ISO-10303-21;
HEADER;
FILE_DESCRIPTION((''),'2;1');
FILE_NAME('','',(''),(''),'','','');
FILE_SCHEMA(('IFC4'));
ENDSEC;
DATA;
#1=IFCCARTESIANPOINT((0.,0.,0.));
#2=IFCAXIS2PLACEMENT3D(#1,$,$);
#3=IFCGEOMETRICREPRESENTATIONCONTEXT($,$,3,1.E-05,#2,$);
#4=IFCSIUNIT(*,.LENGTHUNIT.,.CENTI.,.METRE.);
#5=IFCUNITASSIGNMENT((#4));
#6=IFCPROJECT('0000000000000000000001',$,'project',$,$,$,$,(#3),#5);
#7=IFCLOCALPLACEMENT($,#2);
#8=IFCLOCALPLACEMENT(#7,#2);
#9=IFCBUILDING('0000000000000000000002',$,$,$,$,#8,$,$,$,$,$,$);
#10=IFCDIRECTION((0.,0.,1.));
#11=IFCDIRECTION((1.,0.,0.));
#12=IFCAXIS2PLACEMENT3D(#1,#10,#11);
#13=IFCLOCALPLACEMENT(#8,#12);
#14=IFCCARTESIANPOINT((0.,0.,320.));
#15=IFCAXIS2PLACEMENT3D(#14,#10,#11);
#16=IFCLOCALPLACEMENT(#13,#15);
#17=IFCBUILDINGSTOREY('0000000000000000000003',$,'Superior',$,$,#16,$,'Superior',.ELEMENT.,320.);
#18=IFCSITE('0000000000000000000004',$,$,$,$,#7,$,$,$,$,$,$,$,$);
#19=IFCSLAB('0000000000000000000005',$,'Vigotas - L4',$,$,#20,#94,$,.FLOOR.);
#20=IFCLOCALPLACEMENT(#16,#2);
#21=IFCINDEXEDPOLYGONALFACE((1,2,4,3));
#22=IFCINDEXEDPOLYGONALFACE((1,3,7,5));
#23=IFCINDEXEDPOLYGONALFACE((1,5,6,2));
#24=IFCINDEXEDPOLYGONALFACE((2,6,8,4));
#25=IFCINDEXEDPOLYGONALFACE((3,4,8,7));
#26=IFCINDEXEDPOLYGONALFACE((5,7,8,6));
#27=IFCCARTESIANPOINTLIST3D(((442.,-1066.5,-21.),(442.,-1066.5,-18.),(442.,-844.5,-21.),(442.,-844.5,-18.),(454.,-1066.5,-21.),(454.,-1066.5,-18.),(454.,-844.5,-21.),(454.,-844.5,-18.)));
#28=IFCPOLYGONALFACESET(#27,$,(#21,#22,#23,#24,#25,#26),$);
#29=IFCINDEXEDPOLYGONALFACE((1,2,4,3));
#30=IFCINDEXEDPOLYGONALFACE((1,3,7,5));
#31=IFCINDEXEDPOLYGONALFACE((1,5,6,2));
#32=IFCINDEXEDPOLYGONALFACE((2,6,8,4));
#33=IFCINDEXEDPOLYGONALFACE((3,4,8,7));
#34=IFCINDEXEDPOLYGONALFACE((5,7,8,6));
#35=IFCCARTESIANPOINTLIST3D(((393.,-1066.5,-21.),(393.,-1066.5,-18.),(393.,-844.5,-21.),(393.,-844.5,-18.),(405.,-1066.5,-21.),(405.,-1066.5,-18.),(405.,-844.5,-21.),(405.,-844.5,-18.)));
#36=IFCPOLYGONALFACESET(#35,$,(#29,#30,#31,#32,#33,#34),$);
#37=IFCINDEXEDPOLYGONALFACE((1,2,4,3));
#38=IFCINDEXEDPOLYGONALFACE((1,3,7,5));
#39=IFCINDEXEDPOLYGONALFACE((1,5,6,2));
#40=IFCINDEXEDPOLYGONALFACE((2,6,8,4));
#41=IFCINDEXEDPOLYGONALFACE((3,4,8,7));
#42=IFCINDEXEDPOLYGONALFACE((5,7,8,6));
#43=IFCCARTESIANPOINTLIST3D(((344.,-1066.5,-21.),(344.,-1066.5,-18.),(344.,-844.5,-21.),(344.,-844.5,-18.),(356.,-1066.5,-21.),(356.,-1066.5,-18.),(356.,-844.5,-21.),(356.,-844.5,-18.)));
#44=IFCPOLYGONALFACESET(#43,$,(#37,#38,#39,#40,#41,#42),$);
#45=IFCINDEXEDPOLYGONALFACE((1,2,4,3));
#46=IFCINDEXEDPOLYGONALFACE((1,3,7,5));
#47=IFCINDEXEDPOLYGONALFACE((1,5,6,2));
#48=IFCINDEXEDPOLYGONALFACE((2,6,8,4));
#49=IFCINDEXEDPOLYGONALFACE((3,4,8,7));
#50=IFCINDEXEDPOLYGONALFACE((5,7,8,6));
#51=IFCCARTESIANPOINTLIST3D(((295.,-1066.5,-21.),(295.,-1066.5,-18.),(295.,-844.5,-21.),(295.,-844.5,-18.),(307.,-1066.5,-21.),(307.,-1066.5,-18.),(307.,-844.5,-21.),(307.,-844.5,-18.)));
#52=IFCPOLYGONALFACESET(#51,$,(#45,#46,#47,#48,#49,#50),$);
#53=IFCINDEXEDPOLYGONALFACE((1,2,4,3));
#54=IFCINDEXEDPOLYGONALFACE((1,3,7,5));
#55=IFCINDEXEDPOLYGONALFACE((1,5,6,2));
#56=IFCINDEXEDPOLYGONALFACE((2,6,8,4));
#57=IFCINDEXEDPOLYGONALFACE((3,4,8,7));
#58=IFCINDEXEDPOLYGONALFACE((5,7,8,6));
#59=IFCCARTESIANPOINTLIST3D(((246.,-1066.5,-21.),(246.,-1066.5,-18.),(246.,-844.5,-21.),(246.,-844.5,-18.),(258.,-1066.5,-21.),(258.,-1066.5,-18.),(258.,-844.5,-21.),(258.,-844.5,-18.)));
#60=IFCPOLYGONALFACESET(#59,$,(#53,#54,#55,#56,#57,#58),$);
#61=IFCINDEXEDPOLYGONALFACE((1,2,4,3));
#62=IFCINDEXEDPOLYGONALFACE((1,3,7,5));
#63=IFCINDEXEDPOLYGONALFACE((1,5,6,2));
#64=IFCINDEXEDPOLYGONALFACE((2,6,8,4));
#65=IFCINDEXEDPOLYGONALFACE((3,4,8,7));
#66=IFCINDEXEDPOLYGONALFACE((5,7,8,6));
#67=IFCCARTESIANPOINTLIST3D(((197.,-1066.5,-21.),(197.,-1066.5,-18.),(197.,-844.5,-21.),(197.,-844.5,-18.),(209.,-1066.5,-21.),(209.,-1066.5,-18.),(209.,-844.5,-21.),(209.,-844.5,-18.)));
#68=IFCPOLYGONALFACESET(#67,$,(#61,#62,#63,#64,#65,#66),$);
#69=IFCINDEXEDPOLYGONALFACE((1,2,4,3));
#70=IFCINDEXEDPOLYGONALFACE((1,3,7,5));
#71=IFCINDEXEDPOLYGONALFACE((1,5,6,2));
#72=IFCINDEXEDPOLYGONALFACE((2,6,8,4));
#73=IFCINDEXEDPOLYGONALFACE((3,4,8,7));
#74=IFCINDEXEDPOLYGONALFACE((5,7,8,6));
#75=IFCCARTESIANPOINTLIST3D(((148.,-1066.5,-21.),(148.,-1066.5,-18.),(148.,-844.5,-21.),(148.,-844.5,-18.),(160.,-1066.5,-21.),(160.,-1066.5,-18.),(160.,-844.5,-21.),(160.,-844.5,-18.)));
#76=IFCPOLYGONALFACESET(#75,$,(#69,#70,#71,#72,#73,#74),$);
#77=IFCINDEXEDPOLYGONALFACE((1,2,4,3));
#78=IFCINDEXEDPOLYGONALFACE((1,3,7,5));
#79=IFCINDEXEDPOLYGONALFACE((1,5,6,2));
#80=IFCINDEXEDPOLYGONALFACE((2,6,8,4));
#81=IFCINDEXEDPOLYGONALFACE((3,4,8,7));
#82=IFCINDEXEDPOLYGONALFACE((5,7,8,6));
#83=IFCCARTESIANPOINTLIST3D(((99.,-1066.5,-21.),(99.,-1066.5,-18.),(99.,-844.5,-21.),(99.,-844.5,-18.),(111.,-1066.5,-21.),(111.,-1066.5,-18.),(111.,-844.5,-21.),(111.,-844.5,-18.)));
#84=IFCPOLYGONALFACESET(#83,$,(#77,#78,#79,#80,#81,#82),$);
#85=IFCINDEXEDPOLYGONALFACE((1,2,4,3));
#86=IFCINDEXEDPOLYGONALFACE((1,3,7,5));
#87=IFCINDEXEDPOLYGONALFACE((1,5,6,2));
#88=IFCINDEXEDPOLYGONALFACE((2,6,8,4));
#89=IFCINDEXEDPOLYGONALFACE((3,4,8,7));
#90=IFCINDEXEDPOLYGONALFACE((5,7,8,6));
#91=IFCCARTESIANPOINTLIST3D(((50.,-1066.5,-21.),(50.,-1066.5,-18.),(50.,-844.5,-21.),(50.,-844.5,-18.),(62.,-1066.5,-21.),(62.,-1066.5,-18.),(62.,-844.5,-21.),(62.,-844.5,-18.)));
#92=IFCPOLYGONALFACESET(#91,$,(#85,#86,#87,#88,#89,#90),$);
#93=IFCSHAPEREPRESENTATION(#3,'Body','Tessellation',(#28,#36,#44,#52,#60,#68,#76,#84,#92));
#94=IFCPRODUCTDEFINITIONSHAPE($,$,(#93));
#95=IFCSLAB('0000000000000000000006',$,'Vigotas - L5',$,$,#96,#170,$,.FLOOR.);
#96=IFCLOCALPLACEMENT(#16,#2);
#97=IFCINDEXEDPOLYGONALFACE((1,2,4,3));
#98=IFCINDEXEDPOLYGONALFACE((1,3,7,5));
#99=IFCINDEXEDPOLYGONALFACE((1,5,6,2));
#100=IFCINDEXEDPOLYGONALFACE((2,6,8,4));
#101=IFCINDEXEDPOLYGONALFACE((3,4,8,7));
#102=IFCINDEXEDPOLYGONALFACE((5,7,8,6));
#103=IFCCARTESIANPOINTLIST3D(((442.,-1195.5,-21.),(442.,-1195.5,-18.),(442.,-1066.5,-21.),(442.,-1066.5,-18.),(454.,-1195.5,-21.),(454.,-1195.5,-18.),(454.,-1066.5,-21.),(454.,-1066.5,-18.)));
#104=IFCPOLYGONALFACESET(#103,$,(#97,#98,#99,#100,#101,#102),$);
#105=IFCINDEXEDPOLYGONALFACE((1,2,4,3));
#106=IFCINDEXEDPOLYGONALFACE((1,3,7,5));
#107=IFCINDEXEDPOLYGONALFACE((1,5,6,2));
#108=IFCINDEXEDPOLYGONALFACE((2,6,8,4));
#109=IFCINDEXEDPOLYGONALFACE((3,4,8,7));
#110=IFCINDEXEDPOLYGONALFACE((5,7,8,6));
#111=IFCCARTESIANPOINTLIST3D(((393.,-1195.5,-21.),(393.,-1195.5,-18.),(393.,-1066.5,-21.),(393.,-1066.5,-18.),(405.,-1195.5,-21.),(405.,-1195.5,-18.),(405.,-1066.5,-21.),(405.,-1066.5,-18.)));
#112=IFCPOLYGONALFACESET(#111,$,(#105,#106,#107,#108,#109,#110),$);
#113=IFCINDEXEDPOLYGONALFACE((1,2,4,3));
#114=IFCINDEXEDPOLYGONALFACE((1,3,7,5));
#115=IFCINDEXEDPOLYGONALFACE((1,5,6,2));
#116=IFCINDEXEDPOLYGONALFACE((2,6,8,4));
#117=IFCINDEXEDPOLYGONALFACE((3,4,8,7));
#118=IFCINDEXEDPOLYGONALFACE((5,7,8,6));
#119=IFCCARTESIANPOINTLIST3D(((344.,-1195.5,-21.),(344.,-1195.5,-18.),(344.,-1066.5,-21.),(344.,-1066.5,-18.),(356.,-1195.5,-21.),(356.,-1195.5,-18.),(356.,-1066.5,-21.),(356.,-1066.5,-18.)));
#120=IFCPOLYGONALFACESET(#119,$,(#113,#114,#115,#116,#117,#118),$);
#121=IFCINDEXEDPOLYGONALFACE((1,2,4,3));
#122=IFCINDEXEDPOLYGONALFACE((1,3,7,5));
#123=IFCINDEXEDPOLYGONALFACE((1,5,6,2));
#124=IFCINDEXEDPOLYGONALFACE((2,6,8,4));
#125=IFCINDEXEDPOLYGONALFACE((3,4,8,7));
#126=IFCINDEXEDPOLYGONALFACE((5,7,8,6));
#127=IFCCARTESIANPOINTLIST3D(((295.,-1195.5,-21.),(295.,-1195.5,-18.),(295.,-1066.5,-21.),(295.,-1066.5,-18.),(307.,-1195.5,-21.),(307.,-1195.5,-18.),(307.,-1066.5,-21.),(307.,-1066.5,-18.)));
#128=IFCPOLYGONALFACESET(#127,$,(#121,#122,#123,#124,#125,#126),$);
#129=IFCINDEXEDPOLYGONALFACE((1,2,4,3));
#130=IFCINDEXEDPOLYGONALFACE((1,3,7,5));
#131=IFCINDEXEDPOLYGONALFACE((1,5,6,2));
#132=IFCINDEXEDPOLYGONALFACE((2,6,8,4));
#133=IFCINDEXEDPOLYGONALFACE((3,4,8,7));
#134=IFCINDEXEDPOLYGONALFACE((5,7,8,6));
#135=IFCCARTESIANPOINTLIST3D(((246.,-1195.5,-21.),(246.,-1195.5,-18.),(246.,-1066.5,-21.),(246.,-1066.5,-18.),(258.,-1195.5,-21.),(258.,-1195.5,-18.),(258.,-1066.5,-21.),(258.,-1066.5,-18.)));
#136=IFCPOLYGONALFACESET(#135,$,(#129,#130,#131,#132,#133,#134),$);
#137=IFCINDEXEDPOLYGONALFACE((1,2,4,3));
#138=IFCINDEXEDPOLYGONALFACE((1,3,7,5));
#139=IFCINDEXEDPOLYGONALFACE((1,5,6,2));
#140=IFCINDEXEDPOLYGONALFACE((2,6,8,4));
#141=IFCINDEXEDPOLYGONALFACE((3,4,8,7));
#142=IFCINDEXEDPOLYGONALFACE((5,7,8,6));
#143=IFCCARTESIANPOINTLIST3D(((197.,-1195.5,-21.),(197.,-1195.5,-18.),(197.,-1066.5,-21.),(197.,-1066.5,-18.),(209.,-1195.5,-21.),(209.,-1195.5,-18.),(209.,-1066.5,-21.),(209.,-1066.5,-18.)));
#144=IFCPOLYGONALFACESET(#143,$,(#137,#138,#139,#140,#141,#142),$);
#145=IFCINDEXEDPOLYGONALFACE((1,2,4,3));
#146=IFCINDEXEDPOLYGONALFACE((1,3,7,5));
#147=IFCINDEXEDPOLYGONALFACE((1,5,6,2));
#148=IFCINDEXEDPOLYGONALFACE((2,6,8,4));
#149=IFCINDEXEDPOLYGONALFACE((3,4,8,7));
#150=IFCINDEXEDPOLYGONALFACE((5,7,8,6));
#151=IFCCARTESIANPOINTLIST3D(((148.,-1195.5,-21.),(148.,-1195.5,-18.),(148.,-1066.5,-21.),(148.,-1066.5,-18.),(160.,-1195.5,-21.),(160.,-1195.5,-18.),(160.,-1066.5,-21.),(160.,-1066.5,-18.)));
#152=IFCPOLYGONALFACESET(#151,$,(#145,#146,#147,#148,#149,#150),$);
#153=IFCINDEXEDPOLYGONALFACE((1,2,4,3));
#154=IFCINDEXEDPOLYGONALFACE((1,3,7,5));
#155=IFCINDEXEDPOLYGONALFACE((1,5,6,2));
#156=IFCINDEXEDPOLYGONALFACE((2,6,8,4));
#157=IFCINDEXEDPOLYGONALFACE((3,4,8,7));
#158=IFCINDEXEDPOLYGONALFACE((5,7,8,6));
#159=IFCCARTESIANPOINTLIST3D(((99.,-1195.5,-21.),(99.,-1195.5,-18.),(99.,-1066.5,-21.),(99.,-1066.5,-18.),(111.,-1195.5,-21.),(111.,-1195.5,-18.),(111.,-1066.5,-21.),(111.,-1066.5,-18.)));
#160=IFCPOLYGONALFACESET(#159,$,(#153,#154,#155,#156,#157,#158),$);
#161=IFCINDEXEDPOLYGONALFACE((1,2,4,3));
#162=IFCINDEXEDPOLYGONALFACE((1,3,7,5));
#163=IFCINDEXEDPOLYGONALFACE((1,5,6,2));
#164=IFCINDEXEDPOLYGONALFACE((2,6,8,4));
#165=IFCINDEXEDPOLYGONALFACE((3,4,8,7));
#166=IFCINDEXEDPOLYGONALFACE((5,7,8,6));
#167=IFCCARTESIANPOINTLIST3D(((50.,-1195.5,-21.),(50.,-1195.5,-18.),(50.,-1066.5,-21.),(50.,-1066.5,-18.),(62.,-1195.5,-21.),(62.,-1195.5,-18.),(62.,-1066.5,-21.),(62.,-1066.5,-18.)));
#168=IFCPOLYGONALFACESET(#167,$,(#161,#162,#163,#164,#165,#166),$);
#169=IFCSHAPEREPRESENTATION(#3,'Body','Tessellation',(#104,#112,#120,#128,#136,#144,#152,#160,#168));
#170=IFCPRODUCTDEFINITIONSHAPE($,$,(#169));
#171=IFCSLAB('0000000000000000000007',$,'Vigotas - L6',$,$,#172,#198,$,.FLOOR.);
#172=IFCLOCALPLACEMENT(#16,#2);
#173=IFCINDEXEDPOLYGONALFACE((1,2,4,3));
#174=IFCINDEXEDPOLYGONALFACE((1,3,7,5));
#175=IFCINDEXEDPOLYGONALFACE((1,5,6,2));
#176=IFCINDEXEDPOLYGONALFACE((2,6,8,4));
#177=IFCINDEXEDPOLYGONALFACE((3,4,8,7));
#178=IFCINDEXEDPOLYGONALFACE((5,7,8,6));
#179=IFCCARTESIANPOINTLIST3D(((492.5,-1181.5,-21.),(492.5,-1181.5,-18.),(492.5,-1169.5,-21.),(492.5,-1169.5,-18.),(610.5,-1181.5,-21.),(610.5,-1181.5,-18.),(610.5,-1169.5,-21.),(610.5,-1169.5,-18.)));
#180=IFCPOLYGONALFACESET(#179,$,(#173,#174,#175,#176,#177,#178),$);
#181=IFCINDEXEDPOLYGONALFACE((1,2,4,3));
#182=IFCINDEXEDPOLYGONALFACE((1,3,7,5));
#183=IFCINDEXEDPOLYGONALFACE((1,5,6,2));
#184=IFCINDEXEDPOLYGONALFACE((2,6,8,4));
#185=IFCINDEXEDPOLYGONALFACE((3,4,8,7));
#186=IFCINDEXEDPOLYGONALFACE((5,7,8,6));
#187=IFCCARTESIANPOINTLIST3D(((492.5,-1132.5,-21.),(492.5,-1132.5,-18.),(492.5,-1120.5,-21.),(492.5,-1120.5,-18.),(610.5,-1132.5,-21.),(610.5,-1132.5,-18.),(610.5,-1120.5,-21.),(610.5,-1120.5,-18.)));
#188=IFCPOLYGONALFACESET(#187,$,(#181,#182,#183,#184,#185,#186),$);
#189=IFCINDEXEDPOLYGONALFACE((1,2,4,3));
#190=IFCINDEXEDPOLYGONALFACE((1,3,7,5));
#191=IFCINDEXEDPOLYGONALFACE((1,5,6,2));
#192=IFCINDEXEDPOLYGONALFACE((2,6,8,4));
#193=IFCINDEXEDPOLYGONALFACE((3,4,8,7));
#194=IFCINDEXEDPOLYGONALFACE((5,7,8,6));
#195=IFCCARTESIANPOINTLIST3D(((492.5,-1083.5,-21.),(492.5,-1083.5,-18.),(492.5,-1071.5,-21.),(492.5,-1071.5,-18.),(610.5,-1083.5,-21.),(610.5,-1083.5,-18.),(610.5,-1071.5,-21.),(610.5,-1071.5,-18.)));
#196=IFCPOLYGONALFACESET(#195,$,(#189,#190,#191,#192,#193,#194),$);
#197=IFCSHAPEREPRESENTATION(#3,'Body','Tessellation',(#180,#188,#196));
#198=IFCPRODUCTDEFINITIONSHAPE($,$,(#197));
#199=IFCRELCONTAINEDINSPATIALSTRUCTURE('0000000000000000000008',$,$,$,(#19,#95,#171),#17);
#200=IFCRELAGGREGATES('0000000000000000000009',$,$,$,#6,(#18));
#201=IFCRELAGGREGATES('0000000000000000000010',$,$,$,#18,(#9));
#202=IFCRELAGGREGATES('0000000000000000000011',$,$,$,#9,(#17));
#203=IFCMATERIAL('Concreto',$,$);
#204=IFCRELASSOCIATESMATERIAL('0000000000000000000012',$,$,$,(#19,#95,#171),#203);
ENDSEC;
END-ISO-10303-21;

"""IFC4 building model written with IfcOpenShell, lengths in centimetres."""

from ifc_helpers import new_model, si_unit, frame, origin, origin_with_axes, place, context, project, spatial, polyline, outline, extrude, material, element, save


model = new_model("IFC4")

# Units and contexts
context_of_model = context(None, 3, precision=1e-05, world=origin())
ifc_project = project(units=[si_unit("LENGTHUNIT", "METRE", prefix="CENTI")], contexts=[context_of_model])

# Site, building, storey
site_placement = place(None, origin())
site = spatial("IfcSite", under=ifc_project, at=site_placement)
building_placement = place(site_placement, origin())
building = spatial("IfcBuilding", under=site, at=building_placement)
placement = place(building_placement, origin_with_axes())
storey_placement = place(placement, frame((0.0, 0.0, 320.0), z_axis=(0.0, 0.0, 1.0), x_axis=(1.0, 0.0, 0.0)))
storey = spatial("IfcBuildingStorey", under=building, at=storey_placement, Name="Superior", LongName="Superior", CompositionType="ELEMENT", Elevation=320.0)

# Shared definitions
ifc_material = material(Name="Concreto")

# Slabs
slab_1_placement = place(storey_placement, frame((252.0, -955.5, -18.0), z_axis=(0.0, 0.0, 1.0), x_axis=(1.0, 0.0, 0.0)))
element("IfcSlab", 1, at=slab_1_placement, inside=storey, material=ifc_material, Name="Vigotas - L4", PredefinedType="FLOOR", context=context_of_model, shape_type="SolidModel", body=[
    extrude(outline(polyline([(6.0, 1.5), (-6.0, 1.5), (-6.0, -1.5), (6.0, -1.5), (6.0, 1.5), (6.0, 1.5)])), frame((196.0, -111.0, -1.5), z_axis=(0.0, 1.0, 0.0), x_axis=(1.0, 0.0, 0.0)), (0.0, 0.0, 1.0), 222.0),
    extrude(outline(polyline([(6.0, 1.5), (-6.0, 1.5), (-6.0, -1.5), (6.0, -1.5), (6.0, 1.5), (6.0, 1.5)])), frame((147.0, -111.0, -1.5), z_axis=(0.0, 1.0, 0.0), x_axis=(1.0, 0.0, 0.0)), (0.0, 0.0, 1.0), 222.0),
    extrude(outline(polyline([(6.0, 1.5), (-6.0, 1.5), (-6.0, -1.5), (6.0, -1.5), (6.0, 1.5), (6.0, 1.5)])), frame((98.0, -111.0, -1.5), z_axis=(0.0, 1.0, 0.0), x_axis=(1.0, 0.0, 0.0)), (0.0, 0.0, 1.0), 222.0),
    extrude(outline(polyline([(6.0, 1.5), (-6.0, 1.5), (-6.0, -1.5), (6.0, -1.5), (6.0, 1.5), (6.0, 1.5)])), frame((49.0, -111.0, -1.5), z_axis=(0.0, 1.0, 0.0), x_axis=(1.0, 0.0, 0.0)), (0.0, 0.0, 1.0), 222.0),
    extrude(outline(polyline([(6.0, 1.5), (-6.0, 1.5), (-6.0, -1.5), (6.0, -1.5), (6.0, 1.5), (6.0, 1.5)])), frame((0.0, -111.0, -1.5), z_axis=(0.0, 1.0, 0.0), x_axis=(1.0, 0.0, 0.0)), (0.0, 0.0, 1.0), 222.0),
    extrude(outline(polyline([(6.0, 1.5), (-6.0, 1.5), (-6.0, -1.5), (6.0, -1.5), (6.0, 1.5), (6.0, 1.5)])), frame((-49.0, -111.0, -1.5), z_axis=(0.0, 1.0, 0.0), x_axis=(1.0, 0.0, 0.0)), (0.0, 0.0, 1.0), 222.0),
    extrude(outline(polyline([(6.0, 1.5), (-6.0, 1.5), (-6.0, -1.5), (6.0, -1.5), (6.0, 1.5), (6.0, 1.5)])), frame((-98.0, -111.0, -1.5), z_axis=(0.0, 1.0, 0.0), x_axis=(1.0, 0.0, 0.0)), (0.0, 0.0, 1.0), 222.0),
    extrude(outline(polyline([(6.0, 1.5), (-6.0, 1.5), (-6.0, -1.5), (6.0, -1.5), (6.0, 1.5), (6.0, 1.5)])), frame((-147.0, -111.0, -1.5), z_axis=(0.0, 1.0, 0.0), x_axis=(1.0, 0.0, 0.0)), (0.0, 0.0, 1.0), 222.0),
    extrude(outline(polyline([(6.0, 1.5), (-6.0, 1.5), (-6.0, -1.5), (6.0, -1.5), (6.0, 1.5), (6.0, 1.5)])), frame((-196.0, -111.0, -1.5), z_axis=(0.0, 1.0, 0.0), x_axis=(1.0, 0.0, 0.0)), (0.0, 0.0, 1.0), 222.0),
])
slab_2_placement = place(storey_placement, frame((252.0, -1131.0, -18.0), z_axis=(0.0, 0.0, 1.0), x_axis=(1.0, 0.0, 0.0)))
element("IfcSlab", 2, at=slab_2_placement, inside=storey, material=ifc_material, Name="Vigotas - L5", PredefinedType="FLOOR", context=context_of_model, shape_type="SolidModel", body=[
    extrude(outline(polyline([(6.0, 1.5), (-6.0, 1.5), (-6.0, -1.5), (6.0, -1.5), (6.0, 1.5), (6.0, 1.5)])), frame((196.0, -64.5, -1.5), z_axis=(0.0, 1.0, 0.0), x_axis=(1.0, 0.0, 0.0)), (0.0, 0.0, 1.0), 129.0),
    extrude(outline(polyline([(6.0, 1.5), (-6.0, 1.5), (-6.0, -1.5), (6.0, -1.5), (6.0, 1.5), (6.0, 1.5)])), frame((147.0, -64.5, -1.5), z_axis=(0.0, 1.0, 0.0), x_axis=(1.0, 0.0, 0.0)), (0.0, 0.0, 1.0), 129.0),
    extrude(outline(polyline([(6.0, 1.5), (-6.0, 1.5), (-6.0, -1.5), (6.0, -1.5), (6.0, 1.5), (6.0, 1.5)])), frame((98.0, -64.5, -1.5), z_axis=(0.0, 1.0, 0.0), x_axis=(1.0, 0.0, 0.0)), (0.0, 0.0, 1.0), 129.0),
    extrude(outline(polyline([(6.0, 1.5), (-6.0, 1.5), (-6.0, -1.5), (6.0, -1.5), (6.0, 1.5), (6.0, 1.5)])), frame((49.0, -64.5, -1.5), z_axis=(0.0, 1.0, 0.0), x_axis=(1.0, 0.0, 0.0)), (0.0, 0.0, 1.0), 129.0),
    extrude(outline(polyline([(6.0, 1.5), (-6.0, 1.5), (-6.0, -1.5), (6.0, -1.5), (6.0, 1.5), (6.0, 1.5)])), frame((0.0, -64.5, -1.5), z_axis=(0.0, 1.0, 0.0), x_axis=(1.0, 0.0, 0.0)), (0.0, 0.0, 1.0), 129.0),
    extrude(outline(polyline([(6.0, 1.5), (-6.0, 1.5), (-6.0, -1.5), (6.0, -1.5), (6.0, 1.5), (6.0, 1.5)])), frame((-49.0, -64.5, -1.5), z_axis=(0.0, 1.0, 0.0), x_axis=(1.0, 0.0, 0.0)), (0.0, 0.0, 1.0), 129.0),
    extrude(outline(polyline([(6.0, 1.5), (-6.0, 1.5), (-6.0, -1.5), (6.0, -1.5), (6.0, 1.5), (6.0, 1.5)])), frame((-98.0, -64.5, -1.5), z_axis=(0.0, 1.0, 0.0), x_axis=(1.0, 0.0, 0.0)), (0.0, 0.0, 1.0), 129.0),
    extrude(outline(polyline([(6.0, 1.5), (-6.0, 1.5), (-6.0, -1.5), (6.0, -1.5), (6.0, 1.5), (6.0, 1.5)])), frame((-147.0, -64.5, -1.5), z_axis=(0.0, 1.0, 0.0), x_axis=(1.0, 0.0, 0.0)), (0.0, 0.0, 1.0), 129.0),
    extrude(outline(polyline([(6.0, 1.5), (-6.0, 1.5), (-6.0, -1.5), (6.0, -1.5), (6.0, 1.5), (6.0, 1.5)])), frame((-196.0, -64.5, -1.5), z_axis=(0.0, 1.0, 0.0), x_axis=(1.0, 0.0, 0.0)), (0.0, 0.0, 1.0), 129.0),
])
slab_3_placement = place(storey_placement, frame((551.5, -1126.5, -18.0), z_axis=(0.0, 0.0, 1.0), x_axis=(1.0, 0.0, 0.0)))
element("IfcSlab", 3, at=slab_3_placement, inside=storey, material=ifc_material, Name="Vigotas - L6", PredefinedType="FLOOR", context=context_of_model, shape_type="SolidModel", body=[
    extrude(outline(polyline([(6.0, 1.5), (-6.0, 1.5), (-6.0, -1.5), (6.0, -1.5), (6.0, 1.5), (6.0, 1.5)])), frame((-59.0, -49.0, -1.5), z_axis=(1.0, 0.0, 0.0), x_axis=(0.0, -1.0, 0.0)), (0.0, 0.0, 1.0), 118.0),
    extrude(outline(polyline([(6.0, 1.5), (-6.0, 1.5), (-6.0, -1.5), (6.0, -1.5), (6.0, 1.5), (6.0, 1.5)])), frame((-59.0, 0.0, -1.5), z_axis=(1.0, 0.0, 0.0), x_axis=(0.0, -1.0, 0.0)), (0.0, 0.0, 1.0), 118.0),
    extrude(outline(polyline([(6.0, 1.5), (-6.0, 1.5), (-6.0, -1.5), (6.0, -1.5), (6.0, 1.5), (6.0, 1.5)])), frame((-59.0, 49.0, -1.5), z_axis=(1.0, 0.0, 0.0), x_axis=(0.0, -1.0, 0.0)), (0.0, 0.0, 1.0), 118.0),
])

save(model, "model.ifc")
